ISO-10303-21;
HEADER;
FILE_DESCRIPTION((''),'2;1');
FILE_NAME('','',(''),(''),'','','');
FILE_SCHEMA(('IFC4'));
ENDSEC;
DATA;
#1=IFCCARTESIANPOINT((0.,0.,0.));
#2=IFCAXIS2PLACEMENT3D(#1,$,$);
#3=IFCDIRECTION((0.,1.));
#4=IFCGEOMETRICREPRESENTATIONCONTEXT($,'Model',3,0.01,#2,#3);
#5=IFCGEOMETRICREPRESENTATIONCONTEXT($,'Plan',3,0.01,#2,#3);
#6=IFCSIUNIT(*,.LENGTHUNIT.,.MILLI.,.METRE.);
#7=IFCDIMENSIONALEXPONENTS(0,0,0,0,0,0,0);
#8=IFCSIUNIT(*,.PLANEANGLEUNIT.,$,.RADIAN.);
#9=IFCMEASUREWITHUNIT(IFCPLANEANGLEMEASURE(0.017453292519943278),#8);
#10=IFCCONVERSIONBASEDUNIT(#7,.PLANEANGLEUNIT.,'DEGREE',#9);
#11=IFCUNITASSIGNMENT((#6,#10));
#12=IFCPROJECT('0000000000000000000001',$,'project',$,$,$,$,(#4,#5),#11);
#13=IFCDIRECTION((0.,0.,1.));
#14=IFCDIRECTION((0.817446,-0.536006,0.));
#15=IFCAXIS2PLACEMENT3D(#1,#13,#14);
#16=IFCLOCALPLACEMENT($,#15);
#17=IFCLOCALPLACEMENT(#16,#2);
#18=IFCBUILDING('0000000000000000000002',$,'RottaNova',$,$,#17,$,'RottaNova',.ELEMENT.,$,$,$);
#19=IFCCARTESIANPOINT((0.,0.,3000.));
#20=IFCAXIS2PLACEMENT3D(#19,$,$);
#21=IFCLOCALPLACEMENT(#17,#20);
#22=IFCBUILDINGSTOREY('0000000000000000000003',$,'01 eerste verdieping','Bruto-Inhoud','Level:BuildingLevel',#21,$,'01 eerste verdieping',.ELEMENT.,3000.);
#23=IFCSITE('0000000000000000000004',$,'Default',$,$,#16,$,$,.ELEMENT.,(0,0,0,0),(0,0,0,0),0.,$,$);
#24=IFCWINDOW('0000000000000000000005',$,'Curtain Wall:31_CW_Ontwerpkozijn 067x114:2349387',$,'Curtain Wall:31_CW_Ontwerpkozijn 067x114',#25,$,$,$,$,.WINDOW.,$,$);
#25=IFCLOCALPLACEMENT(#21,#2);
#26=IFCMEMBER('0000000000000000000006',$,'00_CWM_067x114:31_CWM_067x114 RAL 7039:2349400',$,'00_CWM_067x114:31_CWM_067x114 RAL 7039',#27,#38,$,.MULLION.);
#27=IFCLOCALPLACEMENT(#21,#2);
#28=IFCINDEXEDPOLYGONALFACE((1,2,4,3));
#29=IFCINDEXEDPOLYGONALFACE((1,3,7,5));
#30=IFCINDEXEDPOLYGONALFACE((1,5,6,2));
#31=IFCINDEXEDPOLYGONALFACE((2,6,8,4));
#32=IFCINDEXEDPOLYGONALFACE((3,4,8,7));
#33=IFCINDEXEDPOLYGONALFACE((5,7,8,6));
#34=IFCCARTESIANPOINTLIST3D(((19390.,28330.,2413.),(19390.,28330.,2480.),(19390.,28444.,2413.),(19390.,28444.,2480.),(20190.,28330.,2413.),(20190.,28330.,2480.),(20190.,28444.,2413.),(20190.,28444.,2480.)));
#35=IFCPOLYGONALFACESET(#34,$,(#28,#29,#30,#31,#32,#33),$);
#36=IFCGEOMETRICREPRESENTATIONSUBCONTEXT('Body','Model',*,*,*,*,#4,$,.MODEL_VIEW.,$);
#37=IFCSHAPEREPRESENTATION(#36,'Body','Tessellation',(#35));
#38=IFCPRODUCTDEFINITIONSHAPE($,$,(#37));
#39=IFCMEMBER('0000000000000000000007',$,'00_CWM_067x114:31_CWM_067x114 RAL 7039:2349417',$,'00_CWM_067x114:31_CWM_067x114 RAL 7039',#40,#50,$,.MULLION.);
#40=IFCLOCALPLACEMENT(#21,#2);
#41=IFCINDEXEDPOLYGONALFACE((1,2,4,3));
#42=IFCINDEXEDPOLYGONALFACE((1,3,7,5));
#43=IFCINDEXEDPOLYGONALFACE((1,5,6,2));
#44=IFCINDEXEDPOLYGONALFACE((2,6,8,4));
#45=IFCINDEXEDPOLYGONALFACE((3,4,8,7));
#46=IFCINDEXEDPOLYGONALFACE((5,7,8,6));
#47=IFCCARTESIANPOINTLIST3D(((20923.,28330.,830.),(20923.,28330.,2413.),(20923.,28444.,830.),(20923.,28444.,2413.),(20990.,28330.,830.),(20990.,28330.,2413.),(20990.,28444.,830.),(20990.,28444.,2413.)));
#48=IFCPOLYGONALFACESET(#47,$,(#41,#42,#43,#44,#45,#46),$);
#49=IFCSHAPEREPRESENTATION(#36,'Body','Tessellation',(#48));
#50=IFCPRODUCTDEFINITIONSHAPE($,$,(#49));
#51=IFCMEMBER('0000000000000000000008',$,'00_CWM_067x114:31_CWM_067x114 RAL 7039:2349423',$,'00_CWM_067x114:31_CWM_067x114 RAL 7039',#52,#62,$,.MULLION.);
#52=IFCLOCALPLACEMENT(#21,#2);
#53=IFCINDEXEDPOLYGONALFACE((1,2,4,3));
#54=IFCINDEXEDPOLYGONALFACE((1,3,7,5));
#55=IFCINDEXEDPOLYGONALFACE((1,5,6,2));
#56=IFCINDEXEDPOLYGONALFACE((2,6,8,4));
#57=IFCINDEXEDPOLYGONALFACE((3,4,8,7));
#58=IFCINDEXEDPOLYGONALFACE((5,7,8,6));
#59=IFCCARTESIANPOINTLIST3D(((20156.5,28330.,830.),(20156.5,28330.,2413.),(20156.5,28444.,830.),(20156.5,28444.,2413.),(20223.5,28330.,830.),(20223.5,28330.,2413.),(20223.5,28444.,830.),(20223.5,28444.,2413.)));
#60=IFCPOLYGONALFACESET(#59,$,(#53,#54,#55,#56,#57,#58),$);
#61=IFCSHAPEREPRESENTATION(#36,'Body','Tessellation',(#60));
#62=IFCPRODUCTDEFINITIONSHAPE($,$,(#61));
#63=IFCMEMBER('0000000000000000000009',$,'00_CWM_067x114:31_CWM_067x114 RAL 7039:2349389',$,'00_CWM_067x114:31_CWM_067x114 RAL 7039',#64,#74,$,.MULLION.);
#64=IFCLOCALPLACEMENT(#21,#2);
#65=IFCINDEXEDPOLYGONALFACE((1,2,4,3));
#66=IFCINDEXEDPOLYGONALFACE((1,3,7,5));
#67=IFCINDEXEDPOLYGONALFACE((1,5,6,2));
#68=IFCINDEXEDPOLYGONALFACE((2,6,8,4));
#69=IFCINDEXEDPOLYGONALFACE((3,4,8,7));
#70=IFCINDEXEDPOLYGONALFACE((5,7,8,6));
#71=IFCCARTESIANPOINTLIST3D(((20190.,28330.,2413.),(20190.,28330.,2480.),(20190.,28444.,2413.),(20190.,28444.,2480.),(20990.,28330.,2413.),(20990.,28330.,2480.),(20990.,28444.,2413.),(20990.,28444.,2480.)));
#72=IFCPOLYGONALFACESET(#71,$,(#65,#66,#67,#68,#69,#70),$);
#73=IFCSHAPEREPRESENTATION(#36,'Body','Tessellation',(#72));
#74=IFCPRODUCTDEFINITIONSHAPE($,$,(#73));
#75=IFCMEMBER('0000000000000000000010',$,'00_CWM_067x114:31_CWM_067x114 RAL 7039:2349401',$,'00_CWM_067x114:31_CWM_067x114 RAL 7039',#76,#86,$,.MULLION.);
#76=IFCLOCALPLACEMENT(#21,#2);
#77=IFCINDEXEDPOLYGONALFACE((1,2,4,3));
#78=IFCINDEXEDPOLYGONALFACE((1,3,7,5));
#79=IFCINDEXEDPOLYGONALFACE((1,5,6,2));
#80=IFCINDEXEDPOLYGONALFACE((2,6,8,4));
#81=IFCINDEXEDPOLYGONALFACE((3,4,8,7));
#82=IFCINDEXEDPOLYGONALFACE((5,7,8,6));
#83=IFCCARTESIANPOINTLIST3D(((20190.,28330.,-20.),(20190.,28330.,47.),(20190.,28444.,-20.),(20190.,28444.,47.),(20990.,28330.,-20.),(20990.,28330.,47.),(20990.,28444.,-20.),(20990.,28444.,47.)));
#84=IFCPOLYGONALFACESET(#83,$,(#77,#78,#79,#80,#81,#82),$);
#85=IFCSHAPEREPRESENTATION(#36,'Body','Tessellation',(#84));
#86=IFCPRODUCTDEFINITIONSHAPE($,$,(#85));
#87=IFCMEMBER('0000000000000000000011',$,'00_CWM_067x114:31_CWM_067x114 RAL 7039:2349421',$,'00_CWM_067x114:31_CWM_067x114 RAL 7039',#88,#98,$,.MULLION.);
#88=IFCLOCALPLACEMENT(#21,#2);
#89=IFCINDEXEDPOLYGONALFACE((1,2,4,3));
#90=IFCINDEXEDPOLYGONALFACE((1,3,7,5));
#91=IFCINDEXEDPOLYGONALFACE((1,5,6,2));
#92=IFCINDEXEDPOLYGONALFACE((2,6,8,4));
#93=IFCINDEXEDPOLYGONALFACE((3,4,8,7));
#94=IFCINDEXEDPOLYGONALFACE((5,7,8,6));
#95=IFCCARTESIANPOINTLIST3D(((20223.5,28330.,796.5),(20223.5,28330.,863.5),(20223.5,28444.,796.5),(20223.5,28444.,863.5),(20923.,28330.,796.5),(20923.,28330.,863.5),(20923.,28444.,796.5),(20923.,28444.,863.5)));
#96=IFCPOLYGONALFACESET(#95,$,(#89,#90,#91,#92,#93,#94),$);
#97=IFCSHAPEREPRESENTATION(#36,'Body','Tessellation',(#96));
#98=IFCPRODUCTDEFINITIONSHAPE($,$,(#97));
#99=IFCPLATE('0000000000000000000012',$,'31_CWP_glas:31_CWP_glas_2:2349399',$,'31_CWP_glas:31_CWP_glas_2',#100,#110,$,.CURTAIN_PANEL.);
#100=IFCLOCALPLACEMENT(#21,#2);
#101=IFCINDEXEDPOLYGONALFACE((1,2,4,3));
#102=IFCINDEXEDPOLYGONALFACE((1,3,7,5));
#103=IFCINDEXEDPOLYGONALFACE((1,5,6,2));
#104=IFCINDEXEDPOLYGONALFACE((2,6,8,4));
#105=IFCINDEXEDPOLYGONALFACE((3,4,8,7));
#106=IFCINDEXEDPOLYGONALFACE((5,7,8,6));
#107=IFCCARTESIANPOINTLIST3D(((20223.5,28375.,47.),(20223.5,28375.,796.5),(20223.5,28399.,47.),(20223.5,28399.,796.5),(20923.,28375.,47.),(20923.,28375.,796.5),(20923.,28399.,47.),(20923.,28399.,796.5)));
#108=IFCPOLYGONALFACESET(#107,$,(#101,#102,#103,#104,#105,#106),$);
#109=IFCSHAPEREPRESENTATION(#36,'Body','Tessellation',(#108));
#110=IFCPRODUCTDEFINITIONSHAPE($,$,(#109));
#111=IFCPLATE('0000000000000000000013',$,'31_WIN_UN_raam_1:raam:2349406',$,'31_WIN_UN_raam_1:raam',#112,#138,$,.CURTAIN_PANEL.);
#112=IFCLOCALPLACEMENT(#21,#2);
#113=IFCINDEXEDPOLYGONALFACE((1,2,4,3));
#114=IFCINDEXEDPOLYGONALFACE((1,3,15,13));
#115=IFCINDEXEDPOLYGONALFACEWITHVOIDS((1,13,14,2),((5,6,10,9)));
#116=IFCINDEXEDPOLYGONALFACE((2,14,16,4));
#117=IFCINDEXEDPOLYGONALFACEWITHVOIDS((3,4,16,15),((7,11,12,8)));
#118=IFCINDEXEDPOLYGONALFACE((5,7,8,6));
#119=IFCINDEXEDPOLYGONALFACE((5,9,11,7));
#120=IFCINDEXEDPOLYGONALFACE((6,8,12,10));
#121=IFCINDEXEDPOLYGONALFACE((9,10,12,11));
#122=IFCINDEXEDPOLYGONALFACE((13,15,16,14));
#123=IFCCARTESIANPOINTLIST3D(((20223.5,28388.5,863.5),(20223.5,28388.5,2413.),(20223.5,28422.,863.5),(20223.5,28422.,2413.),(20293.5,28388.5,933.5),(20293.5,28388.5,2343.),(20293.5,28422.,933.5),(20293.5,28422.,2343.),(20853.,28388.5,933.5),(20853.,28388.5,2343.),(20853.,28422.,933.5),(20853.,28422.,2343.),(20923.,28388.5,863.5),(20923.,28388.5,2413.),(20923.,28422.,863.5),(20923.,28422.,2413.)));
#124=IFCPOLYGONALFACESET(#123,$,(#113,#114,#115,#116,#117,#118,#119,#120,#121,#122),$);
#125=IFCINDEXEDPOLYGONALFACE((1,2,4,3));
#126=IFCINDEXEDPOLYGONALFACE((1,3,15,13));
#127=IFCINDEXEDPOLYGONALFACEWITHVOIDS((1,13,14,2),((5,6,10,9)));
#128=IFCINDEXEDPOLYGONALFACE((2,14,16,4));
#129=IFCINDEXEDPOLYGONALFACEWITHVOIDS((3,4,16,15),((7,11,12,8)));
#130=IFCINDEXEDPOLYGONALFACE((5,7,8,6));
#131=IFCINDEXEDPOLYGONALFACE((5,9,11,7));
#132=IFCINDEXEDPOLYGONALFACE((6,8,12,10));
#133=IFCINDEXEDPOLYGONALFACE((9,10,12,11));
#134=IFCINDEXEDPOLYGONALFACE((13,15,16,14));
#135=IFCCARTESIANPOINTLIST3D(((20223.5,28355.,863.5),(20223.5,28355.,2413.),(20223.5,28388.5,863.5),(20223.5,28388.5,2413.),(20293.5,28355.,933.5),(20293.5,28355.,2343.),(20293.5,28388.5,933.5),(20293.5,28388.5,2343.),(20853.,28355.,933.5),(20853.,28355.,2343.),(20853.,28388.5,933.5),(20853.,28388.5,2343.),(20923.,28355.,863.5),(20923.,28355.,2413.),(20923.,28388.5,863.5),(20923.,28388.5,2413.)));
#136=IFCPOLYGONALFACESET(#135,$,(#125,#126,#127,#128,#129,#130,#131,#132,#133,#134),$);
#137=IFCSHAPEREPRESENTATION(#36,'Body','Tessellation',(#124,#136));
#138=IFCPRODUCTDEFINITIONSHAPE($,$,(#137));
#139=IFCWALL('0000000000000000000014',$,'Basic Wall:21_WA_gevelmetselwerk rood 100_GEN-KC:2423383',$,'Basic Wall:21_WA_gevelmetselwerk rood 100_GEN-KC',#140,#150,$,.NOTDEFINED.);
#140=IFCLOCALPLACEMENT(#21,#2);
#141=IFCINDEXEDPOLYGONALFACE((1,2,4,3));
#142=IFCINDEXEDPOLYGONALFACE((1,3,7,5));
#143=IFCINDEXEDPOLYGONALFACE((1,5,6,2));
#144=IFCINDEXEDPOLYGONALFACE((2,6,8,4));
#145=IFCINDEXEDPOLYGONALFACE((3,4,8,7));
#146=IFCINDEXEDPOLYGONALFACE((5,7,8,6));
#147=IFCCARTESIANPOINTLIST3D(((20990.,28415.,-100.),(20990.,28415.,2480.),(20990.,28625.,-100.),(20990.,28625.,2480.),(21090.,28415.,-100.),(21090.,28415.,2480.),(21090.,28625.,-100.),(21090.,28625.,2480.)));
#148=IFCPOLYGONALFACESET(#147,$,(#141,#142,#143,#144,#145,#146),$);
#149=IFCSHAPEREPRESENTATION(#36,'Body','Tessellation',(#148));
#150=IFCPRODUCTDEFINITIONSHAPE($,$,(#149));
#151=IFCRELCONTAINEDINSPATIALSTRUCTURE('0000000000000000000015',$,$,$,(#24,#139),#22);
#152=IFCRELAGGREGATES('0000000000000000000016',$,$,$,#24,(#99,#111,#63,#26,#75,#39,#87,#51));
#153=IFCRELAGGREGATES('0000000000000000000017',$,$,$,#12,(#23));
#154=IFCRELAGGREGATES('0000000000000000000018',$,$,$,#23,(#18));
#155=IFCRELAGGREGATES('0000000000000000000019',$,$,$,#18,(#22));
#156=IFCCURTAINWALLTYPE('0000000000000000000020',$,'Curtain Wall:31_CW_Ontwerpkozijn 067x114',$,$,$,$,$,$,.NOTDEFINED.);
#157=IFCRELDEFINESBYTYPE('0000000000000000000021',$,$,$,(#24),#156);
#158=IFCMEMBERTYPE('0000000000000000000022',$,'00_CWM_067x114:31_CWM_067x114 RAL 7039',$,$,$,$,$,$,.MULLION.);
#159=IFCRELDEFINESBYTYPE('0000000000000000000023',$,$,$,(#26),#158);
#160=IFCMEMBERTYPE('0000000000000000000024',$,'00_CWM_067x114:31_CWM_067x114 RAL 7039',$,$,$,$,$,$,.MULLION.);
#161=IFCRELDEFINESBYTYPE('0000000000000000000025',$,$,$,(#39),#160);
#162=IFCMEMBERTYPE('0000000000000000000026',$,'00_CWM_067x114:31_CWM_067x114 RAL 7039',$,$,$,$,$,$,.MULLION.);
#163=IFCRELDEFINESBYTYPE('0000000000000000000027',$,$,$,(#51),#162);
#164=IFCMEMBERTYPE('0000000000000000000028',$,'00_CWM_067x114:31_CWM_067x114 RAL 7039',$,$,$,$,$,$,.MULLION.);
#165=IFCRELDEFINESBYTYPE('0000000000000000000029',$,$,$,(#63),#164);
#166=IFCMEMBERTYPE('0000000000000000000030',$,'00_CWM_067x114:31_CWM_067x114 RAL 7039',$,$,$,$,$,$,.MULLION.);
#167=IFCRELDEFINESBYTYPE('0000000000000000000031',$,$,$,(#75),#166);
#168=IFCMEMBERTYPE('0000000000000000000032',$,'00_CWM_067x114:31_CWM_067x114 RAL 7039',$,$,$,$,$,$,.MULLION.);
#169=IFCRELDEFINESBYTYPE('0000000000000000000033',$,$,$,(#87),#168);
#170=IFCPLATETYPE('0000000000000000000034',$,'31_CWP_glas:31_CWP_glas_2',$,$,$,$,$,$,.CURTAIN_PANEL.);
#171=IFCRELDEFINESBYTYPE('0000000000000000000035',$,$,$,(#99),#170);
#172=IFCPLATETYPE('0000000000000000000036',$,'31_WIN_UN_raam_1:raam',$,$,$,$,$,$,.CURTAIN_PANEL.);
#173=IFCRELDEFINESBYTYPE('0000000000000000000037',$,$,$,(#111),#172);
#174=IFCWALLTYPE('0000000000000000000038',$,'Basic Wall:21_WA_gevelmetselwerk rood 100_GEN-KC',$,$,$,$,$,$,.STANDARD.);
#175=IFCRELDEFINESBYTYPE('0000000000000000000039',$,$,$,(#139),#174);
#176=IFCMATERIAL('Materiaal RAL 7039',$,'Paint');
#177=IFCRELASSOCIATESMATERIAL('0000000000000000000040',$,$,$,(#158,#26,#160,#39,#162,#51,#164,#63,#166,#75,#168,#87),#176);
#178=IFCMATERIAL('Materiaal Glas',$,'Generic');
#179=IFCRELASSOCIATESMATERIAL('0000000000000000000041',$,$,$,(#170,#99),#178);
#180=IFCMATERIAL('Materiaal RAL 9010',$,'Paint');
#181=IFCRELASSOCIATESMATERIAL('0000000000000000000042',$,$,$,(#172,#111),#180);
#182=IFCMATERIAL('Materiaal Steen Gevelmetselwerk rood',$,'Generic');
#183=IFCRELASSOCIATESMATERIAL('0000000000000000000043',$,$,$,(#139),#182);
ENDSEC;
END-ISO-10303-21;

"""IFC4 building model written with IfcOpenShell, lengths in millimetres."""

from ifc_helpers import new_model, entity, si_unit, converted_unit, direction, frame, origin, place, context, subcontext, project, spatial, indexed_curve, outline, extrude, source, transform, mapped, material, type_object, type_shapes, element, aggregate, save


model = new_model("IFC4")

# Units and contexts
model_context = context("Model", 3, precision=0.01, world=origin(), true_north=direction((0.0, 1.0)))
plan_context = context("Plan", 3, precision=0.01, world=origin(), true_north=direction((0.0, 1.0)))
body_context = subcontext(model_context, "Body", "Model", "MODEL_VIEW")
ifc_project = project(units=[si_unit("LENGTHUNIT", "METRE", prefix="MILLI"), converted_unit("PLANEANGLEUNIT", "DEGREE", entity("IfcPlaneAngleMeasure", 0.017453292519943278), si_unit("PLANEANGLEUNIT", "RADIAN"), dimensions=[0, 0, 0, 0, 0, 0, 0])], contexts=[model_context, plan_context])

# Site, building, storey
site_placement = place(None, frame((0.0, 0.0, 0.0), z_axis=(0.0, 0.0, 1.0), x_axis=(0.817446, -0.536006, 0.0)))
site = spatial("IfcSite", under=ifc_project, at=site_placement, Name="Default", CompositionType="ELEMENT", RefLatitude=(0, 0, 0, 0), RefLongitude=(0, 0, 0, 0), RefElevation=0.0)
building_placement = place(site_placement, origin())
building = spatial("IfcBuilding", under=site, at=building_placement, Name="RottaNova", LongName="RottaNova", CompositionType="ELEMENT")
storey_placement = place(building_placement, frame((0.0, 0.0, 3000.0)))
storey = spatial("IfcBuildingStorey", under=building, at=storey_placement, Name="01 eerste verdieping", Description="Bruto-Inhoud", ObjectType="Level:BuildingLevel", LongName="01 eerste verdieping", CompositionType="ELEMENT", Elevation=3000.0)

# Shared definitions
curtain_wall_type = type_object("IfcCurtainWallType", Name="Curtain Wall:31_CW_Ontwerpkozijn 067x114", PredefinedType="NOTDEFINED")
ifc_material_1 = material(Name="Materiaal RAL 7039", Category="Paint")

# Window, members, plates
window_1_placement = place(storey_placement, frame((0.0, 0.0, -3000.0)))
window_1 = element("IfcWindow", 1, at=window_1_placement, inside=storey, type_object=curtain_wall_type, Name="Curtain Wall:31_CW_Ontwerpkozijn 067x114:2349387", ObjectType="Curtain Wall:31_CW_Ontwerpkozijn 067x114", PredefinedType="WINDOW")
member_type_1 = type_object("IfcMemberType", Name="00_CWM_067x114:31_CWM_067x114 RAL 7039", PredefinedType="MULLION", material=ifc_material_1)
shared_shape_1 = source(origin(), body_context, "Body", "SweptSolid", [
    extrude(outline(indexed_curve([(-33.5, -57.0), (33.5, -57.0), (33.5, 57.0), (-33.5, 57.0), (-33.5, -57.0)], self_intersect=False)), frame((-33.5, -57.0, -800.0), z_axis=(0.0, 0.0, 1.0), x_axis=(-1.0, 0.0, 0.0)), (0.0, 0.0, 1.0), 800.0),
])
type_shapes(member_type_1, [shared_shape_1])
member_1_placement = place(window_1_placement, frame((20190.0, 28330.0, 5480.0), z_axis=(1.0, 0.0, 0.0), x_axis=(0.0, 0.0, 1.0)))
member_1 = element("IfcMember", 2, at=member_1_placement, type_object=member_type_1, material=ifc_material_1, Name="00_CWM_067x114:31_CWM_067x114 RAL 7039:2349400", ObjectType="00_CWM_067x114:31_CWM_067x114 RAL 7039", PredefinedType="MULLION", context=body_context, shape_type="MappedRepresentation", body=[
    mapped(shared_shape_1, transform((0.0, 0.0, 0.0), scale=1.0)),
])
member_type_2 = type_object("IfcMemberType", Name="00_CWM_067x114:31_CWM_067x114 RAL 7039", PredefinedType="MULLION", material=ifc_material_1)
shared_shape_2 = source(origin(), body_context, "Body", "SweptSolid", [
    extrude(outline(indexed_curve([(-33.5, -57.0), (33.5, -57.0), (33.5, 57.0), (-33.5, 57.0), (-33.5, -57.0)], self_intersect=False)), frame((-33.5, -57.0, -1583.0), z_axis=(0.0, 0.0, 1.0), x_axis=(-1.0, 0.0, 0.0)), (0.0, 0.0, 1.0), 1583.0),
])
type_shapes(member_type_2, [shared_shape_2])
member_2_placement = place(window_1_placement, frame((20990.0, 28330.0, 3830.0), z_axis=(0.0, 0.0, -1.0), x_axis=(1.0, 0.0, 0.0)))
member_2 = element("IfcMember", 3, at=member_2_placement, type_object=member_type_2, material=ifc_material_1, Name="00_CWM_067x114:31_CWM_067x114 RAL 7039:2349417", ObjectType="00_CWM_067x114:31_CWM_067x114 RAL 7039", PredefinedType="MULLION", context=body_context, shape_type="MappedRepresentation", body=[
    mapped(shared_shape_2, transform((0.0, 0.0, 0.0), scale=1.0)),
])
member_type_3 = type_object("IfcMemberType", Name="00_CWM_067x114:31_CWM_067x114 RAL 7039", PredefinedType="MULLION", material=ifc_material_1)
shared_shape_3 = source(origin(), body_context, "Body", "SweptSolid", [
    extrude(outline(indexed_curve([(-33.5, -57.0), (33.5, -57.0), (33.5, 57.0), (-33.5, 57.0), (-33.5, -57.0)], self_intersect=False)), frame((0.0, -57.0, -1583.0), z_axis=(0.0, 0.0, 1.0), x_axis=(-1.0, 0.0, 0.0)), (0.0, 0.0, 1.0), 1583.0),
])
type_shapes(member_type_3, [shared_shape_3])
member_3_placement = place(window_1_placement, frame((20190.0, 28330.0, 3830.0), z_axis=(0.0, 0.0, -1.0), x_axis=(1.0, 0.0, 0.0)))
member_3 = element("IfcMember", 4, at=member_3_placement, type_object=member_type_3, material=ifc_material_1, Name="00_CWM_067x114:31_CWM_067x114 RAL 7039:2349423", ObjectType="00_CWM_067x114:31_CWM_067x114 RAL 7039", PredefinedType="MULLION", context=body_context, shape_type="MappedRepresentation", body=[
    mapped(shared_shape_3, transform((0.0, 0.0, 0.0), scale=1.0)),
])
member_type_4 = type_object("IfcMemberType", Name="00_CWM_067x114:31_CWM_067x114 RAL 7039", PredefinedType="MULLION", material=ifc_material_1)
shared_shape_4 = source(origin(), body_context, "Body", "SweptSolid", [
    extrude(outline(indexed_curve([(-33.5, -57.0), (33.5, -57.0), (33.5, 57.0), (-33.5, 57.0), (-33.5, -57.0)], self_intersect=False)), frame((-33.5, -57.0, -800.0), z_axis=(0.0, 0.0, 1.0), x_axis=(-1.0, 0.0, 0.0)), (0.0, 0.0, 1.0), 800.0),
])
type_shapes(member_type_4, [shared_shape_4])
member_4_placement = place(window_1_placement, frame((20990.0, 28330.0, 5480.0), z_axis=(1.0, 0.0, 0.0), x_axis=(0.0, 0.0, 1.0)))
member_4 = element("IfcMember", 5, at=member_4_placement, type_object=member_type_4, material=ifc_material_1, Name="00_CWM_067x114:31_CWM_067x114 RAL 7039:2349389", ObjectType="00_CWM_067x114:31_CWM_067x114 RAL 7039", PredefinedType="MULLION", context=body_context, shape_type="MappedRepresentation", body=[
    mapped(shared_shape_4, transform((0.0, 0.0, 0.0), scale=1.0)),
])
member_type_5 = type_object("IfcMemberType", Name="00_CWM_067x114:31_CWM_067x114 RAL 7039", PredefinedType="MULLION", material=ifc_material_1)
shared_shape_5 = source(origin(), body_context, "Body", "SweptSolid", [
    extrude(outline(indexed_curve([(-33.5, -57.0), (33.5, -57.0), (33.5, 57.0), (-33.5, 57.0), (-33.5, -57.0)], self_intersect=False)), frame((-33.5, -57.0, -800.0), z_axis=(0.0, 0.0, 1.0), x_axis=(-1.0, 0.0, 0.0)), (0.0, 0.0, 1.0), 800.0),
])
type_shapes(member_type_5, [shared_shape_5])
member_5_placement = place(window_1_placement, frame((20190.0, 28330.0, 2980.0), z_axis=(-1.0, 0.0, 0.0), x_axis=(0.0, 0.0, -1.0)))
member_5 = element("IfcMember", 6, at=member_5_placement, type_object=member_type_5, material=ifc_material_1, Name="00_CWM_067x114:31_CWM_067x114 RAL 7039:2349401", ObjectType="00_CWM_067x114:31_CWM_067x114 RAL 7039", PredefinedType="MULLION", context=body_context, shape_type="MappedRepresentation", body=[
    mapped(shared_shape_5, transform((0.0, 0.0, 0.0), scale=1.0)),
])
member_type_6 = type_object("IfcMemberType", Name="00_CWM_067x114:31_CWM_067x114 RAL 7039", PredefinedType="MULLION", material=ifc_material_1)
shared_shape_6 = source(origin(), body_context, "Body", "SweptSolid", [
    extrude(outline(indexed_curve([(-33.5, -57.0), (33.5, -57.0), (33.5, 57.0), (-33.5, 57.0), (-33.5, -57.0)], self_intersect=False)), frame((0.0, -57.0, -699.5), z_axis=(0.0, 0.0, 1.0), x_axis=(-1.0, 0.0, 0.0)), (0.0, 0.0, 1.0), 699.5),
])
type_shapes(member_type_6, [shared_shape_6])
member_6_placement = place(window_1_placement, frame((20923.0, 28330.0, 3830.0), z_axis=(1.0, 0.0, 0.0), x_axis=(0.0, 0.0, 1.0)))
member_6 = element("IfcMember", 7, at=member_6_placement, type_object=member_type_6, material=ifc_material_1, Name="00_CWM_067x114:31_CWM_067x114 RAL 7039:2349421", ObjectType="00_CWM_067x114:31_CWM_067x114 RAL 7039", PredefinedType="MULLION", context=body_context, shape_type="MappedRepresentation", body=[
    mapped(shared_shape_6, transform((0.0, 0.0, 0.0), scale=1.0)),
])
ifc_material_2 = material(Name="Materiaal Glas", Category="Generic")
plate_type_1 = type_object("IfcPlateType", Name="31_CWP_glas:31_CWP_glas_2", PredefinedType="CURTAIN_PANEL", material=ifc_material_2)
shared_shape_7 = source(origin(), body_context, "Body", "SweptSolid", [
    extrude(outline(indexed_curve([(-12.0, -349.8), (12.0, -349.8), (12.0, 349.8), (-12.0, 349.8), (-12.0, -349.8)], self_intersect=False)), frame((0.0, 57.0, 0.0), z_axis=(0.0, 0.0, 1.0), x_axis=(0.0, 1.0, 0.0)), (0.0, 0.0, 1.0), 749.5),
])
type_shapes(plate_type_1, [shared_shape_7])
plate_1_placement = place(window_1_placement, frame((20573.3, 28330.0, 3047.0)))
plate_1 = element("IfcPlate", 8, at=plate_1_placement, type_object=plate_type_1, material=ifc_material_2, Name="31_CWP_glas:31_CWP_glas_2:2349399", ObjectType="31_CWP_glas:31_CWP_glas_2", PredefinedType="CURTAIN_PANEL", context=body_context, shape_type="MappedRepresentation", body=[
    mapped(shared_shape_7, transform((0.0, 0.0, 0.0), scale=1.0)),
])
ifc_material_3 = material(Name="Materiaal RAL 9010", Category="Paint")
plate_type_2 = type_object("IfcPlateType", Name="31_WIN_UN_raam_1:raam", PredefinedType="CURTAIN_PANEL", material=ifc_material_3)
shared_shape_8 = source(origin(), body_context, "Body", "SweptSolid", [
    extrude(outline(indexed_curve([(-349.7, -774.8), (349.7, -774.8), (349.7, 774.8), (-349.7, 774.8), (-349.7, -774.8)], self_intersect=False), holes=[indexed_curve([(-279.7, 704.8), (279.7, 704.8), (279.7, -704.8), (-279.7, -704.8), (-279.7, 704.8)], self_intersect=False)]), frame((0.0, 58.5, 774.8), z_axis=(0.0, 1.0, 0.0), x_axis=(1.0, 0.0, 0.0)), (0.0, 0.0, 1.0), 33.5),
    extrude(outline(indexed_curve([(-349.7, -774.8), (349.7, -774.8), (349.7, 774.8), (-349.7, 774.8), (-349.7, -774.8)], self_intersect=False), holes=[indexed_curve([(-279.7, 704.7), (279.7, 704.7), (279.7, -704.8), (-279.7, -704.8), (-279.7, 704.7)], self_intersect=False)]), frame((0.0, 25.0, 774.8), z_axis=(0.0, 1.0, 0.0), x_axis=(1.0, 0.0, 0.0)), (0.0, 0.0, 1.0), 33.5),
])
type_shapes(plate_type_2, [shared_shape_8])
plate_2_placement = place(window_1_placement, frame((20573.3, 28330.0, 3863.5)))
plate_2 = element("IfcPlate", 9, at=plate_2_placement, type_object=plate_type_2, material=ifc_material_3, Name="31_WIN_UN_raam_1:raam:2349406", ObjectType="31_WIN_UN_raam_1:raam", PredefinedType="CURTAIN_PANEL", context=body_context, shape_type="MappedRepresentation", body=[
    mapped(shared_shape_8, transform((0.0, 0.0, 0.0), scale=1.0)),
])
aggregate(window_1, [plate_1, plate_2, member_4, member_1, member_5, member_2, member_6, member_3])

# Wall
ifc_material_4 = material(Name="Materiaal Steen Gevelmetselwerk rood", Category="Generic")
wall_type_1 = type_object("IfcWallType", Name="Basic Wall:21_WA_gevelmetselwerk rood 100_GEN-KC", PredefinedType="STANDARD")
wall_1_placement = place(storey_placement, frame((21040.0, 28415.0, -100.0), z_axis=(0.0, 0.0, 1.0), x_axis=(0.0, 1.0, 0.0)))
element("IfcWall", 10, at=wall_1_placement, inside=storey, type_object=wall_type_1, material=ifc_material_4, Name="Basic Wall:21_WA_gevelmetselwerk rood 100_GEN-KC:2423383", ObjectType="Basic Wall:21_WA_gevelmetselwerk rood 100_GEN-KC", PredefinedType="NOTDEFINED", context=body_context, shape_type="SweptSolid", body=[
    extrude(outline(indexed_curve([(210.0, 50.0), (0.0, 50.0), (0.0, -50.0), (210.0, -50.0), (210.0, 50.0)], self_intersect=False)), origin(), (0.0, 0.0, 1.0), 2580.0),
])

save(model, "model.ifc")
